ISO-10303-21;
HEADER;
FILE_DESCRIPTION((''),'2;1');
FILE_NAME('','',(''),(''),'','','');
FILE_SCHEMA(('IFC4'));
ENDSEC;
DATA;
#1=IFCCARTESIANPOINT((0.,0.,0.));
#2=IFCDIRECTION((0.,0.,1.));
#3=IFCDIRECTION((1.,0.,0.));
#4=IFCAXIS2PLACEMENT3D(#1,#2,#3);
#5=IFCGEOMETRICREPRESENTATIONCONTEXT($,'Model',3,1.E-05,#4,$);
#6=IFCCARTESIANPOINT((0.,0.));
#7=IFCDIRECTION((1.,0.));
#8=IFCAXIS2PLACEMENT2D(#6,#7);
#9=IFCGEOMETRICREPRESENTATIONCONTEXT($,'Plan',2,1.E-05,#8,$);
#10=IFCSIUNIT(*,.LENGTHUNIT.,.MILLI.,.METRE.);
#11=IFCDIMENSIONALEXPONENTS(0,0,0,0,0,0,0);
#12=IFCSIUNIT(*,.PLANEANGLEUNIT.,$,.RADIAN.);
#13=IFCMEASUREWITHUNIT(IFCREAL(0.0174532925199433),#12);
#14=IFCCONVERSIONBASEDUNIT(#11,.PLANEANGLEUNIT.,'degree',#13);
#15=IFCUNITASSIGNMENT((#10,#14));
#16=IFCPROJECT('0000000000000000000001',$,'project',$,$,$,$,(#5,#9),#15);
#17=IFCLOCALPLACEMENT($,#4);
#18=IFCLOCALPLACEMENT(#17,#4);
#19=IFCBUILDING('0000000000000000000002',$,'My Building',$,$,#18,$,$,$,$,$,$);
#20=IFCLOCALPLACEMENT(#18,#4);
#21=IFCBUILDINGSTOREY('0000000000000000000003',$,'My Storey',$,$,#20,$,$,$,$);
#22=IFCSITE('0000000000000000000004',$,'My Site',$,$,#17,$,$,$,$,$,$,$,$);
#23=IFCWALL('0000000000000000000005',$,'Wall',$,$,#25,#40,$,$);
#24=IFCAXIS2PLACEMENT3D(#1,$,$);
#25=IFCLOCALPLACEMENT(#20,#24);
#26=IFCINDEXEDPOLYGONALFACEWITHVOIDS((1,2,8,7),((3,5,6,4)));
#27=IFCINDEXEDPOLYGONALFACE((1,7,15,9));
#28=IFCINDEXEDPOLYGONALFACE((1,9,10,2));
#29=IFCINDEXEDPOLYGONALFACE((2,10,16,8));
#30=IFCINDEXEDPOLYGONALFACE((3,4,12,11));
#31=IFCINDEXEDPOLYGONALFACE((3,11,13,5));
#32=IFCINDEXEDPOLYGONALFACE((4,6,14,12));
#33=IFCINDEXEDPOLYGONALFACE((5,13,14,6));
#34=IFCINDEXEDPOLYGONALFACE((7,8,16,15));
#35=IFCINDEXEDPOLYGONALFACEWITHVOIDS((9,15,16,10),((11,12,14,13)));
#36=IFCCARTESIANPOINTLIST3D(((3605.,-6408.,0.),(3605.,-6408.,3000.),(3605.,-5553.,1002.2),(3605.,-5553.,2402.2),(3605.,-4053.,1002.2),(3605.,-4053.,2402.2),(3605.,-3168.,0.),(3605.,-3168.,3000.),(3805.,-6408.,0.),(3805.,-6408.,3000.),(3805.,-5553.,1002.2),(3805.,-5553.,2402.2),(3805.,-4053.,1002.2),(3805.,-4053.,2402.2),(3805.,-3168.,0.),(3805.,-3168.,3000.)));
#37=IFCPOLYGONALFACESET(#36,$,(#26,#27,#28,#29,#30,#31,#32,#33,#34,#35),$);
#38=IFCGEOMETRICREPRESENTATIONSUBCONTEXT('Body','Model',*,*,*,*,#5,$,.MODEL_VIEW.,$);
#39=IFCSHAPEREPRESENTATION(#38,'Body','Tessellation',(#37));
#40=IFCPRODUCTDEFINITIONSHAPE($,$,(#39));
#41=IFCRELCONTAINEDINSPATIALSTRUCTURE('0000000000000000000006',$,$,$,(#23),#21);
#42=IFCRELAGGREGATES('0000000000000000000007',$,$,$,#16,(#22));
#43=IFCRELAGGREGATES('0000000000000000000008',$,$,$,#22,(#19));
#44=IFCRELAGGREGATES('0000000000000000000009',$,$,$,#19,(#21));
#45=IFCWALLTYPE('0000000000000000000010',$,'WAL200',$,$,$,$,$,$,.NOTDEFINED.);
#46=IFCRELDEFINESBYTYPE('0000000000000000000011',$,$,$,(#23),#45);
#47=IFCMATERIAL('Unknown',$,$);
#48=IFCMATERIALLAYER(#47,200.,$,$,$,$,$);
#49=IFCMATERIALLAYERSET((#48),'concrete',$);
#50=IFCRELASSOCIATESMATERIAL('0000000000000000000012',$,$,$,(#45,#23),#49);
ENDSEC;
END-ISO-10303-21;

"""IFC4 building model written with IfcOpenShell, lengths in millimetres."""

from ifc_helpers import new_model, entity, si_unit, converted_unit, frame, origin_with_axes, origin_2d_with_axis, place, context, subcontext, project, spatial, line, indexed_curve, outline, extrude, source, transform, mapped, material, layer, layer_set, layer_usage, type_object, element, save


model = new_model("IFC4")

# Units and contexts
model_context = context("Model", 3, precision=1e-05, world=origin_with_axes())
plan_context = context("Plan", 2, precision=1e-05, world=origin_2d_with_axis())
body_context_1 = subcontext(model_context, "Body", "Model", "MODEL_VIEW")
ifc_project = project(units=[si_unit("LENGTHUNIT", "METRE", prefix="MILLI"), converted_unit("PLANEANGLEUNIT", "degree", entity("IfcReal", 0.0174532925199433), si_unit("PLANEANGLEUNIT", "RADIAN"), dimensions=[0, 0, 0, 0, 0, 0, 0])], contexts=[model_context, plan_context])

# Site, building, storey
site_placement = place(None, origin_with_axes())
site = spatial("IfcSite", under=ifc_project, at=site_placement, Name="My Site")
building_placement = place(site_placement, origin_with_axes())
building = spatial("IfcBuilding", under=site, at=building_placement, Name="My Building")
storey_placement = place(building_placement, origin_with_axes())
storey = spatial("IfcBuildingStorey", under=building, at=storey_placement, Name="My Storey")

# Wall, opening
ifc_material_1 = material(Name="Unknown")
ifc_layer_1 = layer(ifc_material_1, 200.0)
ifc_layer_set_1 = layer_set([ifc_layer_1], Name="concrete")
ifc_layer_usage_1 = layer_usage(ifc_layer_set_1, "AXIS2", "POSITIVE", 0.0)
wall_type = type_object("IfcWallType", Name="WAL200", PredefinedType="NOTDEFINED", material=ifc_layer_set_1)
wall_placement = place(storey_placement, frame((3805.0, -6408.0, 0.0), z_axis=(0.0, 0.0, 1.0), x_axis=(0.000002, 1.0, 0.0)))
wall = element("IfcWall", 1, at=wall_placement, inside=storey, type_object=wall_type, material=ifc_layer_usage_1, Name="Wall", context=body_context_1, shape_type="SweptSolid", body=[
    extrude(outline(indexed_curve([(0.0, 0.0), (0.0, 200.0), (3240.0, 200.0), (3240.0, 0.0), (0.0, 0.0)], self_intersect=False)), origin_with_axes(), (0.0, 0.0, 1.0), 3000.0),
])
shared_shape_1 = source(origin_with_axes(), body_context_1, "Body", "SweptSolid", [
    extrude(outline(indexed_curve([(0.0, 0.0), (1500.0, 0.0), (1500.0, 1400.0), (0.0, 1400.0)], segments=[line(1, 2, 3, 4, 1)])), frame((0.0, -100.0, 0.0), z_axis=(0.0, -1.0, 0.0), x_axis=(1.0, 0.0, 0.0)), (0.0, 0.0, -1.0), 400.0),
])
opening_1_placement = place(wall_placement, frame((855.0, 0.0, 1002.2), z_axis=(0.0, 0.0, 1.0), x_axis=(1.0, 0.0, 0.0)))
element("IfcOpeningElement", 2, at=opening_1_placement, cuts=wall, PredefinedType="OPENING", context=body_context_1, shape_type="MappedRepresentation", body=[
    mapped(shared_shape_1, transform((0.0, 0.0, 0.0), x_axis=(1.0, 0.0, 0.0), y_axis=(0.0, 1.0, 0.0), z_axis=(0.0, 0.0, 1.0), scale=1.0)),
])

save(model, "model.ifc")
